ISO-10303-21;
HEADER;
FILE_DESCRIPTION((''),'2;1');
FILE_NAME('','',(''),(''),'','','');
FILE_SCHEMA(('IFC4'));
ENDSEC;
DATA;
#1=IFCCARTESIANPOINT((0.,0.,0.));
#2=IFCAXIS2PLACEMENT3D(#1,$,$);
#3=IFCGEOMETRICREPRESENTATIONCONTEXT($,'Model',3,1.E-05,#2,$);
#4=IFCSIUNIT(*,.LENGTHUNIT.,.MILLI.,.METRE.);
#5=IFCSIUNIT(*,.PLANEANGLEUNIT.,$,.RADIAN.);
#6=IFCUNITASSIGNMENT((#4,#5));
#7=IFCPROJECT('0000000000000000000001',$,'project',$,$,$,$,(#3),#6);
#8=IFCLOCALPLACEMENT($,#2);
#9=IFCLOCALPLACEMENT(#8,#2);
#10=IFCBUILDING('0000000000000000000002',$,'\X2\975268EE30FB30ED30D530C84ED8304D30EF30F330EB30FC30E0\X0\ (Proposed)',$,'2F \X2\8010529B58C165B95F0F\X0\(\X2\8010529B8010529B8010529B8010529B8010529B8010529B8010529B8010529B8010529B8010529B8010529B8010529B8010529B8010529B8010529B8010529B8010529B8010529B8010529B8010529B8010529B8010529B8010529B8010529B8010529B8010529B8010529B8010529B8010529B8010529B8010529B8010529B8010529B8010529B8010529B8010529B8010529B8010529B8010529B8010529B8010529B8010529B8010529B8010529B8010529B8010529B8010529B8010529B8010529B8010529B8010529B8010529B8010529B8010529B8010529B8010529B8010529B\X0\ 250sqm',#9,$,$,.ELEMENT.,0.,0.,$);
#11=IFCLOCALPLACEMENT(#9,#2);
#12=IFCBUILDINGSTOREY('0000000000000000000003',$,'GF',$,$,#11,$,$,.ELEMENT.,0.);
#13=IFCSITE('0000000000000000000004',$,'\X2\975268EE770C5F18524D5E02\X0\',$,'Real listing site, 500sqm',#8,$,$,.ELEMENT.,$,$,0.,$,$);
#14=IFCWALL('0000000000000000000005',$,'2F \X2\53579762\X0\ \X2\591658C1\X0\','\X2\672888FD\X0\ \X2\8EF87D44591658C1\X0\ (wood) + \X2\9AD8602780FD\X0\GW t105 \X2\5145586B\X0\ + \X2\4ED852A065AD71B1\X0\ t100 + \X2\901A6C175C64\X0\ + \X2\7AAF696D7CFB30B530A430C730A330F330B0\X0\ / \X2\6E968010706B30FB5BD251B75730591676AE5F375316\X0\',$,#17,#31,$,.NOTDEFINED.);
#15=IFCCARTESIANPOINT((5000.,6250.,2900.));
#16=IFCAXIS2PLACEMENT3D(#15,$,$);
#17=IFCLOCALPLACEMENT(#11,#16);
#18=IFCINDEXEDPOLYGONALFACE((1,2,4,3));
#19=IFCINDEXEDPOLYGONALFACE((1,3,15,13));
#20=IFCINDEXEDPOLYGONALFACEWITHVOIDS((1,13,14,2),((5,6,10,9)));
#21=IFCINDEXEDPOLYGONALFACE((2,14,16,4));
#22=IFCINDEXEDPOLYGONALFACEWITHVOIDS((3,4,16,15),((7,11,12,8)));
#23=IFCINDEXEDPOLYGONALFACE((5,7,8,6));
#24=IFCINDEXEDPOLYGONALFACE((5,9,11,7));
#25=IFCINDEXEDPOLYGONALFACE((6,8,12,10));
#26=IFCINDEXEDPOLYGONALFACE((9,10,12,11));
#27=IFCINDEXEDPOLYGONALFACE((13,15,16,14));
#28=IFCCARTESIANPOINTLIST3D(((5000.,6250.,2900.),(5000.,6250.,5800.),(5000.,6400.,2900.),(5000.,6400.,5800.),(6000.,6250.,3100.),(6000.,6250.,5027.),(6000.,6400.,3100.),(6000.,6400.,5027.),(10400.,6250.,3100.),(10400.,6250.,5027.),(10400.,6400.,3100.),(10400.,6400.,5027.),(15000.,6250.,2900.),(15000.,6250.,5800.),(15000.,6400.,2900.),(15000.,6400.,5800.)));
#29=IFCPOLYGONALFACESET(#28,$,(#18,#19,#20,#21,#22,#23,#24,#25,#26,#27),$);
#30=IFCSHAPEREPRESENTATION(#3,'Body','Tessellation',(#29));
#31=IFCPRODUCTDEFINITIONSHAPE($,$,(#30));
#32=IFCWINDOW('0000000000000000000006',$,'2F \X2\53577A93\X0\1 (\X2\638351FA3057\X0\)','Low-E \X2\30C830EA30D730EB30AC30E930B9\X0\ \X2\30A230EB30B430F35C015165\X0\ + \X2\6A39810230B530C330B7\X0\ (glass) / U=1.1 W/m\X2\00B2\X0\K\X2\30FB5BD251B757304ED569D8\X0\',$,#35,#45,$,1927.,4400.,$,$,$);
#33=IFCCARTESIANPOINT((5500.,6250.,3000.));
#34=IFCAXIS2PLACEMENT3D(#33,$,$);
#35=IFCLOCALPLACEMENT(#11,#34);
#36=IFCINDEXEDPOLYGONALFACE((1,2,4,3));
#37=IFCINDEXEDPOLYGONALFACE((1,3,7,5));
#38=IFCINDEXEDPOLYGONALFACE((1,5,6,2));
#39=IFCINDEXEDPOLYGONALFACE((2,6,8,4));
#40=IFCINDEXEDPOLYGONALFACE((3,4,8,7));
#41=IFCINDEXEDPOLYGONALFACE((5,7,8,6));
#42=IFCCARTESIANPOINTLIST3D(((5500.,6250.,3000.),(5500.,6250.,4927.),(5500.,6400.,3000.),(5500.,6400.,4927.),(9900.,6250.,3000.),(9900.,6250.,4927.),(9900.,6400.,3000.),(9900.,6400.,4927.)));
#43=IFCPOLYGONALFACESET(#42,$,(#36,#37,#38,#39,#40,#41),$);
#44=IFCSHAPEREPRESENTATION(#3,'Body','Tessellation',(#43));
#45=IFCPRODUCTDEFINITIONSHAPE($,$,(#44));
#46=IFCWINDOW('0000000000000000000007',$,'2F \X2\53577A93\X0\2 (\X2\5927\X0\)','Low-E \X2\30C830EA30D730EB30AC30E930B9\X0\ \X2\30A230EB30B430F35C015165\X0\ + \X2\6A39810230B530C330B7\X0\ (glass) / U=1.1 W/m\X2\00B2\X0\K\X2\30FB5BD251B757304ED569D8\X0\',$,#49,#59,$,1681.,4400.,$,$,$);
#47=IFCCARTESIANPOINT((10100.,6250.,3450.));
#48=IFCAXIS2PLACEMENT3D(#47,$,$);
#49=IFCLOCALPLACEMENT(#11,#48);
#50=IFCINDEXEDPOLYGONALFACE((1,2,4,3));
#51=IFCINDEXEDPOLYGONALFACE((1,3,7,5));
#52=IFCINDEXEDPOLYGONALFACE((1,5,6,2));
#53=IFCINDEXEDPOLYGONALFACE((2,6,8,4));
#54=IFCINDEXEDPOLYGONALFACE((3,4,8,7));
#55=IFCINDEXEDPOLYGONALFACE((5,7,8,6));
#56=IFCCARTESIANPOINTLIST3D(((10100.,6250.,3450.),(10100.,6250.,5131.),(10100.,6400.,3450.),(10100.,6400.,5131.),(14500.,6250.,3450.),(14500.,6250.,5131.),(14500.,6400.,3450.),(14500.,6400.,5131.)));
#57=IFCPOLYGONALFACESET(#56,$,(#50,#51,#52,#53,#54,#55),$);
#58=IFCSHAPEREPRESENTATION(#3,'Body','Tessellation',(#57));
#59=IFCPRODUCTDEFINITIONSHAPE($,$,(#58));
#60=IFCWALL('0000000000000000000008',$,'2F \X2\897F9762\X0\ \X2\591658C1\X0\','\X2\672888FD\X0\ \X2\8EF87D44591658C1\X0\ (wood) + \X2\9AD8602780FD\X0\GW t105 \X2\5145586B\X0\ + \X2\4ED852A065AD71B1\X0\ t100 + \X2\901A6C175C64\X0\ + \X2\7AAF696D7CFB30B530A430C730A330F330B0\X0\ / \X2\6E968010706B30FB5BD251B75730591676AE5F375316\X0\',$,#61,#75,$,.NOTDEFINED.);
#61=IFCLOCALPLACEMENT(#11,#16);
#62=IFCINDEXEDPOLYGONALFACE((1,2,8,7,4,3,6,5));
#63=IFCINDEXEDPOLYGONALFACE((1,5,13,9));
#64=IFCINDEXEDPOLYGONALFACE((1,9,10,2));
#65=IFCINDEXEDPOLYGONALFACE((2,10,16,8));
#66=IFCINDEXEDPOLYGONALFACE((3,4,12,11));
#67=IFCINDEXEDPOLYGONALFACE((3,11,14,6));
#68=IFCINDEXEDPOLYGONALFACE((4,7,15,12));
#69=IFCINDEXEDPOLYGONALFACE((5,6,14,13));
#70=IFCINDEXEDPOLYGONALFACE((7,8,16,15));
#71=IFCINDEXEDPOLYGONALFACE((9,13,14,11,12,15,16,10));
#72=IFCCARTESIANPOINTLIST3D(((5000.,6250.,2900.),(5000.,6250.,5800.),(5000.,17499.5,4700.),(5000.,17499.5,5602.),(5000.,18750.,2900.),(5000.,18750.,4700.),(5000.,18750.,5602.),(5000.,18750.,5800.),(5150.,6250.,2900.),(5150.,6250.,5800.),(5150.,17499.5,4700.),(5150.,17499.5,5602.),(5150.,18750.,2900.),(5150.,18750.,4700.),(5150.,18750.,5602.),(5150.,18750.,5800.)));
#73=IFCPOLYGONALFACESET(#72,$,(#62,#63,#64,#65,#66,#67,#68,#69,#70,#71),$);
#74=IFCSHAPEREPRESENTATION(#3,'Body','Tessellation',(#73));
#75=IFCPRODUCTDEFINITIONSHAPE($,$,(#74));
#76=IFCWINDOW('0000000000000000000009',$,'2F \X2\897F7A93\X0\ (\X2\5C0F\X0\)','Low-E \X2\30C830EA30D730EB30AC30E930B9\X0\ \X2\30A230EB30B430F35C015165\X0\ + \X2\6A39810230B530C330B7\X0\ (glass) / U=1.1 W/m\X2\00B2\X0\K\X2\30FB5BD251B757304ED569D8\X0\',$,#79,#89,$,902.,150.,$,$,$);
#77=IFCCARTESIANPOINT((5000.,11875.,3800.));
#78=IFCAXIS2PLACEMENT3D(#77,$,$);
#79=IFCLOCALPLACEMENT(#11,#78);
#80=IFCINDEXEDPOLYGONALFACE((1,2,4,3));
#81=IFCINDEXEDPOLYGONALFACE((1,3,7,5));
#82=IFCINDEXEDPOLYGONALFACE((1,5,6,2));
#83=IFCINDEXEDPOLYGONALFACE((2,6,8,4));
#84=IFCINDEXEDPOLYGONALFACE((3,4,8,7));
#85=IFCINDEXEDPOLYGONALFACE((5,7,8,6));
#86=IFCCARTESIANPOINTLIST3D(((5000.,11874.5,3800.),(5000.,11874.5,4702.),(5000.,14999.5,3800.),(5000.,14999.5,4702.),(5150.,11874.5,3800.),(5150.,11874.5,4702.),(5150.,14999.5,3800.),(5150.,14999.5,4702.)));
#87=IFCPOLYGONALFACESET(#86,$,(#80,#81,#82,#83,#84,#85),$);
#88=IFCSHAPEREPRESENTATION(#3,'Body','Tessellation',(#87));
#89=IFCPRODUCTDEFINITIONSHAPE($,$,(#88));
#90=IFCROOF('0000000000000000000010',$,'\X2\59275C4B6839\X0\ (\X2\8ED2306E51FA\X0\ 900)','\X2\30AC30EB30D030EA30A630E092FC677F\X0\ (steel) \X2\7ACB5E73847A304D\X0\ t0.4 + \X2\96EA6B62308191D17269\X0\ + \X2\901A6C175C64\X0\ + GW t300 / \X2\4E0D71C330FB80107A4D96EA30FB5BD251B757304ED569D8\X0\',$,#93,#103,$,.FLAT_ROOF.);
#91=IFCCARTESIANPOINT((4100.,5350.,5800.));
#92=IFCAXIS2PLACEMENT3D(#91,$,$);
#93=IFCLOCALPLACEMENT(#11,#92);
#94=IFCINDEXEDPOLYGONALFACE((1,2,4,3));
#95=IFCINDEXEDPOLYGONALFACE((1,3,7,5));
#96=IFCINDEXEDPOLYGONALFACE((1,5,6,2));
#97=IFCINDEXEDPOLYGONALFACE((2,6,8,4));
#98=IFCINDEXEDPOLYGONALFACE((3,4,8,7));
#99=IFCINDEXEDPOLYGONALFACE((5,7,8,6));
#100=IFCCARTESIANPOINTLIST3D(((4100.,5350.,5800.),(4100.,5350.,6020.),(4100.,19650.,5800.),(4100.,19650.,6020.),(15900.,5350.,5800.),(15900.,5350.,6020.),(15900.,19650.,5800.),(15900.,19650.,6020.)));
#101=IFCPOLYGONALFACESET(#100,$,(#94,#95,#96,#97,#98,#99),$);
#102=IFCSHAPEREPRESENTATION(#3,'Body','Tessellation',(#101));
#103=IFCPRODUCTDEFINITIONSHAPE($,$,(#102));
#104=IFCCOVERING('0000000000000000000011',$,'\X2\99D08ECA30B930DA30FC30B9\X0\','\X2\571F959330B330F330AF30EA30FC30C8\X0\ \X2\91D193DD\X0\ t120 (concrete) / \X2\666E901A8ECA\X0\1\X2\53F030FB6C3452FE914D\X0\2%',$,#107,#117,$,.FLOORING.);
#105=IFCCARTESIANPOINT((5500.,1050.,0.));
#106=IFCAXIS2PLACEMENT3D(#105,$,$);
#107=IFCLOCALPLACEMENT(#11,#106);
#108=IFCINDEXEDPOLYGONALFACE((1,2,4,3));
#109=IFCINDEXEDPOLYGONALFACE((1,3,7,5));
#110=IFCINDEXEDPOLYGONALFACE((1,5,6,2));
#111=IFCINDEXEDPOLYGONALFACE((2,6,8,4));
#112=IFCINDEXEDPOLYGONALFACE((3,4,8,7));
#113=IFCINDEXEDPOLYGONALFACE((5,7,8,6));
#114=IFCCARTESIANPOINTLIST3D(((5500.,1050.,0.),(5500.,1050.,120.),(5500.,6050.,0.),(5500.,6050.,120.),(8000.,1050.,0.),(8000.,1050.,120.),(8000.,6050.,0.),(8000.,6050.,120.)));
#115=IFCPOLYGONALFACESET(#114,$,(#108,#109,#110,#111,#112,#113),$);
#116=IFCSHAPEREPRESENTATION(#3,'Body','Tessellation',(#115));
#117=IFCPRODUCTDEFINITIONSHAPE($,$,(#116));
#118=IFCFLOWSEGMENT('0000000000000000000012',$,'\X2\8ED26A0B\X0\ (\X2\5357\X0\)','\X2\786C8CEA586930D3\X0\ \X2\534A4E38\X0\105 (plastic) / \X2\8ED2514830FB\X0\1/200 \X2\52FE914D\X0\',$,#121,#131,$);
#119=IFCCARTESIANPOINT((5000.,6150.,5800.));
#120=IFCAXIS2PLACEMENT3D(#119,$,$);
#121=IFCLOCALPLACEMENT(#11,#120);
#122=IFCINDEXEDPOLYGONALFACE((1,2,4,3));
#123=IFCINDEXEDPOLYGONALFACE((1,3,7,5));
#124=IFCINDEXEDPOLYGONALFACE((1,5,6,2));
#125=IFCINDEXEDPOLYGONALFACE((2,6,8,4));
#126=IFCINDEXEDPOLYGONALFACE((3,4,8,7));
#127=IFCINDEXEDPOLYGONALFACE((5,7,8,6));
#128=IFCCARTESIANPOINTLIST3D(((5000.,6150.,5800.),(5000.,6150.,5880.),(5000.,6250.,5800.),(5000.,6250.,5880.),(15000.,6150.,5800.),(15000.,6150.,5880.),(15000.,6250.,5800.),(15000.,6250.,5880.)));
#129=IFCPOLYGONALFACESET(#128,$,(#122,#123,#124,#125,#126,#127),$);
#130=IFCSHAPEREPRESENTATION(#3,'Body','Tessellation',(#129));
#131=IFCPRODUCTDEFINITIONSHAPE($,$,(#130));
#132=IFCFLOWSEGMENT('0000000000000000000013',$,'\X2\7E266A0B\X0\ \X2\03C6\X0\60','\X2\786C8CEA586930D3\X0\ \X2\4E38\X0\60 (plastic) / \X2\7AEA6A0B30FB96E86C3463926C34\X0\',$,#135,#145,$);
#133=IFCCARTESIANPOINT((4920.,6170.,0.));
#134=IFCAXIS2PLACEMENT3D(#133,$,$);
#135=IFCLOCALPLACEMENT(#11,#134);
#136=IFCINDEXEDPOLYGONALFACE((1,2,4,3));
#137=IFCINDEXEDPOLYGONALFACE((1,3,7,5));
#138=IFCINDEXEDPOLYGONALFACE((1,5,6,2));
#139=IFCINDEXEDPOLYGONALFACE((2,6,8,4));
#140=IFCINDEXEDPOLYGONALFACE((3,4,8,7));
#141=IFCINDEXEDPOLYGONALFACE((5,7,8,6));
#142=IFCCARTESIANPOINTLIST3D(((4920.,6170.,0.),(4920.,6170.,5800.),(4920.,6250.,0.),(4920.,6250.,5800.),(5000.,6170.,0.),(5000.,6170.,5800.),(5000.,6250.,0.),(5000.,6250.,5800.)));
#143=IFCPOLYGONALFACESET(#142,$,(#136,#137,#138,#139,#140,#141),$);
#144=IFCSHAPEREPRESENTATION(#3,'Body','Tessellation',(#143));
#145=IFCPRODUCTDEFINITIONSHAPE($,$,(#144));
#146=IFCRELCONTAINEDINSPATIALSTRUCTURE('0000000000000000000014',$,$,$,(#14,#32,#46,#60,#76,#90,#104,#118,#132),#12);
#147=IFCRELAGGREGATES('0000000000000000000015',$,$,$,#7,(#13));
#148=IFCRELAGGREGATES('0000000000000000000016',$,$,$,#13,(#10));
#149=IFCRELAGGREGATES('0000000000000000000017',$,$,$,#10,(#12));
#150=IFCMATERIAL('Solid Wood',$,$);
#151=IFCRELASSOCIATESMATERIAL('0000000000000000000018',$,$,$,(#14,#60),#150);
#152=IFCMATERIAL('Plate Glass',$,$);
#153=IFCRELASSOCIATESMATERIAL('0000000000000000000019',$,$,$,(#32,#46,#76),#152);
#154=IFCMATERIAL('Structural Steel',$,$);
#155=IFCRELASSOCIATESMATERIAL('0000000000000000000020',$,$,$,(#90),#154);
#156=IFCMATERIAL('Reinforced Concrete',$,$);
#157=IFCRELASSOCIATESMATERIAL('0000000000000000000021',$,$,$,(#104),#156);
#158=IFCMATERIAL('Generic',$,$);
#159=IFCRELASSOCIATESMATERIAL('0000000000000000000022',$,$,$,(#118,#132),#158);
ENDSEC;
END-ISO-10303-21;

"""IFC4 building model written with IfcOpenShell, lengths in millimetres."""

from ifc_helpers import new_model, si_unit, frame, frame_2d, origin, place, context, project, spatial, rectangle, extrude, material, element, fill, save


model = new_model("IFC4")

# Units and contexts
model_context = context("Model", 3, precision=1e-05, world=origin())
ifc_project = project(units=[si_unit("LENGTHUNIT", "METRE", prefix="MILLI"), si_unit("PLANEANGLEUNIT", "RADIAN")], contexts=[model_context])

# Site, building, storey
site_placement = place(None, origin())
site = spatial("IfcSite", under=ifc_project, at=site_placement, Name="青森県弘前市", ObjectType="Real listing site, 500sqm", CompositionType="ELEMENT", RefElevation=0.0)
building_placement = place(site_placement, origin())
building = spatial("IfcBuilding", under=site, at=building_placement, Name="青森・ロフト付きワンルーム (Proposed)", ObjectType="2F 耐力壁方式(耐力耐力耐力耐力耐力耐力耐力耐力耐力耐力耐力耐力耐力耐力耐力耐力耐力耐力耐力耐力耐力耐力耐力耐力耐力耐力耐力耐力耐力耐力耐力耐力耐力耐力耐力耐力耐力耐力耐力耐力耐力耐力耐力耐力耐力耐力耐力耐力耐力耐力耐力耐力耐力耐力耐力耐力耐力 250sqm", CompositionType="ELEMENT", ElevationOfRefHeight=0.0, ElevationOfTerrain=0.0)
storey_placement = place(building_placement, origin())
storey = spatial("IfcBuildingStorey", under=building, at=storey_placement, Name="GF", CompositionType="ELEMENT", Elevation=0.0)

# Shared definitions
ifc_material_1 = material(Name="Solid Wood")

# Shared definitions
ifc_material_2 = material(Name="Reinforced Concrete")

# Shared definitions
ifc_material_3 = material(Name="Plate Glass")

# Wall, openings, windows
wall_1_placement = place(storey_placement, frame((5000.0, 6250.0, 2900.0)))
wall_1 = element("IfcWall", 1, at=wall_1_placement, inside=storey, material=ifc_material_1, Name="2F 南面 外壁", Description="木製 軸組外壁 (wood) + 高性能GW t105 充填 + 付加断熱 t100 + 通気層 + 窯業系サイディング / 準耐火・寒冷地外皮強化", PredefinedType="NOTDEFINED", context=model_context, shape_type="SweptSolid", body=[
    extrude(rectangle(XDim=10000.0, YDim=150.0, at=frame_2d((5000.0, 75.0))), frame((5000.0, 6250.0, 2900.0)), (0.0, 0.0, 1.0), 2900.0),
])
opening_1_placement = place(storey_placement, frame((5500.0, 6250.0, 3000.0)))
opening_1 = element("IfcOpeningElement", 2, at=opening_1_placement, cuts=wall_1, PredefinedType="NOTDEFINED", context=model_context, shape_type="SweptSolid", body=[
    extrude(rectangle(XDim=4400.0, YDim=150.0, at=frame_2d((2200.0, 75.0))), frame((5500.0, 6250.0, 3000.0)), (0.0, 0.0, 1.0), 1927.0),
])
opening_2_placement = place(storey_placement, frame((10100.0, 6250.0, 3450.0)))
opening_2 = element("IfcOpeningElement", 3, at=opening_2_placement, cuts=wall_1, PredefinedType="NOTDEFINED", context=model_context, shape_type="SweptSolid", body=[
    extrude(rectangle(XDim=4400.0, YDim=150.0, at=frame_2d((2200.0, 75.0))), frame((10100.0, 6250.0, 3450.0)), (0.0, 0.0, 1.0), 1681.0),
])
window_1_placement = place(storey_placement, frame((5500.0, 6250.0, 3000.0)))
window_1 = element("IfcWindow", 4, at=window_1_placement, inside=storey, material=ifc_material_3, Name="2F 南窓1 (掃出し)", Description="Low-E トリプルガラス アルゴン封入 + 樹脂サッシ (glass) / U=1.1 W/m²K・寒冷地仕様", OverallHeight=1927.0, OverallWidth=4400.0, context=model_context, shape_type="SweptSolid", body=[
    extrude(rectangle(XDim=4400.0, YDim=150.0, at=frame_2d((2200.0, 75.0))), frame((5500.0, 6250.0, 3000.0)), (0.0, 0.0, 1.0), 1927.0),
])
fill(opening_1, window_1)
window_2_placement = place(storey_placement, frame((10100.0, 6250.0, 3450.0)))
window_2 = element("IfcWindow", 5, at=window_2_placement, inside=storey, material=ifc_material_3, Name="2F 南窓2 (大)", Description="Low-E トリプルガラス アルゴン封入 + 樹脂サッシ (glass) / U=1.1 W/m²K・寒冷地仕様", OverallHeight=1681.0, OverallWidth=4400.0, context=model_context, shape_type="SweptSolid", body=[
    extrude(rectangle(XDim=4400.0, YDim=150.0, at=frame_2d((2200.0, 75.0))), frame((10100.0, 6250.0, 3450.0)), (0.0, 0.0, 1.0), 1681.0),
])
fill(opening_2, window_2)

# Wall, opening, window
wall_2_placement = place(storey_placement, frame((5000.0, 6250.0, 2900.0)))
wall_2 = element("IfcWall", 6, at=wall_2_placement, inside=storey, material=ifc_material_1, Name="2F 西面 外壁", Description="木製 軸組外壁 (wood) + 高性能GW t105 充填 + 付加断熱 t100 + 通気層 + 窯業系サイディング / 準耐火・寒冷地外皮強化", PredefinedType="NOTDEFINED", context=model_context, shape_type="SweptSolid", body=[
    extrude(rectangle(XDim=150.0, YDim=12500.0, at=frame_2d((75.0, 6250.0))), frame((5000.0, 6250.0, 2900.0)), (0.0, 0.0, 1.0), 2900.0),
])
opening_3_placement = place(storey_placement, frame((5000.0, 11875.0, 3800.0)))
opening_3 = element("IfcOpeningElement", 7, at=opening_3_placement, cuts=wall_2, PredefinedType="NOTDEFINED", context=model_context, shape_type="SweptSolid", body=[
    extrude(rectangle(XDim=150.0, YDim=3125.0, at=frame_2d((75.0, 1562.0))), frame((5000.0, 11875.0, 3800.0)), (0.0, 0.0, 1.0), 902.0),
])
window_3_placement = place(storey_placement, frame((5000.0, 11875.0, 3800.0)))
window_3 = element("IfcWindow", 8, at=window_3_placement, inside=storey, material=ifc_material_3, Name="2F 西窓 (小)", Description="Low-E トリプルガラス アルゴン封入 + 樹脂サッシ (glass) / U=1.1 W/m²K・寒冷地仕様", OverallHeight=902.0, OverallWidth=150.0, context=model_context, shape_type="SweptSolid", body=[
    extrude(rectangle(XDim=150.0, YDim=3125.0, at=frame_2d((75.0, 1562.0))), frame((5000.0, 11875.0, 3800.0)), (0.0, 0.0, 1.0), 902.0),
])
fill(opening_3, window_3)

# Roof
ifc_material_4 = material(Name="Structural Steel")
roof_placement = place(storey_placement, frame((4100.0, 5350.0, 5800.0)))
element("IfcRoof", 9, at=roof_placement, inside=storey, material=ifc_material_4, Name="大屋根 (軒の出 900)", Description="ガルバリウム鋼板 (steel) 立平葺き t0.4 + 雪止め金物 + 通気層 + GW t300 / 不燃・耐積雪・寒冷地仕様", PredefinedType="FLAT_ROOF", context=model_context, shape_type="SweptSolid", body=[
    extrude(rectangle(XDim=11800.0, YDim=14300.0, at=frame_2d((5900.0, 7150.0))), frame((4100.0, 5350.0, 5800.0)), (0.0, 0.0, 1.0), 220.0),
])

# Covering
covering_placement = place(storey_placement, frame((5500.0, 1050.0, 0.0)))
element("IfcCovering", 10, at=covering_placement, inside=storey, material=ifc_material_2, Name="駐車スペース", Description="土間コンクリート 金鏝 t120 (concrete) / 普通車1台・水勾配2%", PredefinedType="FLOORING", context=model_context, shape_type="SweptSolid", body=[
    extrude(rectangle(XDim=2500.0, YDim=5000.0, at=frame_2d((1250.0, 2500.0))), frame((5500.0, 1050.0, 0.0)), (0.0, 0.0, 1.0), 120.0),
])

# Flow segments
ifc_material_5 = material(Name="Generic")
flow_segment_1_placement = place(storey_placement, frame((5000.0, 6150.0, 5800.0)))
element("IfcFlowSegment", 11, at=flow_segment_1_placement, inside=storey, material=ifc_material_5, Name="軒樋 (南)", Description="硬質塩ビ 半丸105 (plastic) / 軒先・1/200 勾配", context=model_context, shape_type="SweptSolid", body=[
    extrude(rectangle(XDim=10000.0, YDim=100.0, at=frame_2d((5000.0, 50.0))), frame((5000.0, 6150.0, 5800.0)), (0.0, 0.0, 1.0), 80.0),
])
flow_segment_2_placement = place(storey_placement, frame((4920.0, 6170.0, 0.0)))
element("IfcFlowSegment", 12, at=flow_segment_2_placement, inside=storey, material=ifc_material_5, Name="縦樋 φ60", Description="硬質塩ビ 丸60 (plastic) / 竪樋・雨水排水", context=model_context, shape_type="SweptSolid", body=[
    extrude(rectangle(XDim=80.0, YDim=80.0, at=frame_2d((40.0, 40.0))), frame((4920.0, 6170.0, 0.0)), (0.0, 0.0, 1.0), 5800.0),
])

save(model, "model.ifc")
